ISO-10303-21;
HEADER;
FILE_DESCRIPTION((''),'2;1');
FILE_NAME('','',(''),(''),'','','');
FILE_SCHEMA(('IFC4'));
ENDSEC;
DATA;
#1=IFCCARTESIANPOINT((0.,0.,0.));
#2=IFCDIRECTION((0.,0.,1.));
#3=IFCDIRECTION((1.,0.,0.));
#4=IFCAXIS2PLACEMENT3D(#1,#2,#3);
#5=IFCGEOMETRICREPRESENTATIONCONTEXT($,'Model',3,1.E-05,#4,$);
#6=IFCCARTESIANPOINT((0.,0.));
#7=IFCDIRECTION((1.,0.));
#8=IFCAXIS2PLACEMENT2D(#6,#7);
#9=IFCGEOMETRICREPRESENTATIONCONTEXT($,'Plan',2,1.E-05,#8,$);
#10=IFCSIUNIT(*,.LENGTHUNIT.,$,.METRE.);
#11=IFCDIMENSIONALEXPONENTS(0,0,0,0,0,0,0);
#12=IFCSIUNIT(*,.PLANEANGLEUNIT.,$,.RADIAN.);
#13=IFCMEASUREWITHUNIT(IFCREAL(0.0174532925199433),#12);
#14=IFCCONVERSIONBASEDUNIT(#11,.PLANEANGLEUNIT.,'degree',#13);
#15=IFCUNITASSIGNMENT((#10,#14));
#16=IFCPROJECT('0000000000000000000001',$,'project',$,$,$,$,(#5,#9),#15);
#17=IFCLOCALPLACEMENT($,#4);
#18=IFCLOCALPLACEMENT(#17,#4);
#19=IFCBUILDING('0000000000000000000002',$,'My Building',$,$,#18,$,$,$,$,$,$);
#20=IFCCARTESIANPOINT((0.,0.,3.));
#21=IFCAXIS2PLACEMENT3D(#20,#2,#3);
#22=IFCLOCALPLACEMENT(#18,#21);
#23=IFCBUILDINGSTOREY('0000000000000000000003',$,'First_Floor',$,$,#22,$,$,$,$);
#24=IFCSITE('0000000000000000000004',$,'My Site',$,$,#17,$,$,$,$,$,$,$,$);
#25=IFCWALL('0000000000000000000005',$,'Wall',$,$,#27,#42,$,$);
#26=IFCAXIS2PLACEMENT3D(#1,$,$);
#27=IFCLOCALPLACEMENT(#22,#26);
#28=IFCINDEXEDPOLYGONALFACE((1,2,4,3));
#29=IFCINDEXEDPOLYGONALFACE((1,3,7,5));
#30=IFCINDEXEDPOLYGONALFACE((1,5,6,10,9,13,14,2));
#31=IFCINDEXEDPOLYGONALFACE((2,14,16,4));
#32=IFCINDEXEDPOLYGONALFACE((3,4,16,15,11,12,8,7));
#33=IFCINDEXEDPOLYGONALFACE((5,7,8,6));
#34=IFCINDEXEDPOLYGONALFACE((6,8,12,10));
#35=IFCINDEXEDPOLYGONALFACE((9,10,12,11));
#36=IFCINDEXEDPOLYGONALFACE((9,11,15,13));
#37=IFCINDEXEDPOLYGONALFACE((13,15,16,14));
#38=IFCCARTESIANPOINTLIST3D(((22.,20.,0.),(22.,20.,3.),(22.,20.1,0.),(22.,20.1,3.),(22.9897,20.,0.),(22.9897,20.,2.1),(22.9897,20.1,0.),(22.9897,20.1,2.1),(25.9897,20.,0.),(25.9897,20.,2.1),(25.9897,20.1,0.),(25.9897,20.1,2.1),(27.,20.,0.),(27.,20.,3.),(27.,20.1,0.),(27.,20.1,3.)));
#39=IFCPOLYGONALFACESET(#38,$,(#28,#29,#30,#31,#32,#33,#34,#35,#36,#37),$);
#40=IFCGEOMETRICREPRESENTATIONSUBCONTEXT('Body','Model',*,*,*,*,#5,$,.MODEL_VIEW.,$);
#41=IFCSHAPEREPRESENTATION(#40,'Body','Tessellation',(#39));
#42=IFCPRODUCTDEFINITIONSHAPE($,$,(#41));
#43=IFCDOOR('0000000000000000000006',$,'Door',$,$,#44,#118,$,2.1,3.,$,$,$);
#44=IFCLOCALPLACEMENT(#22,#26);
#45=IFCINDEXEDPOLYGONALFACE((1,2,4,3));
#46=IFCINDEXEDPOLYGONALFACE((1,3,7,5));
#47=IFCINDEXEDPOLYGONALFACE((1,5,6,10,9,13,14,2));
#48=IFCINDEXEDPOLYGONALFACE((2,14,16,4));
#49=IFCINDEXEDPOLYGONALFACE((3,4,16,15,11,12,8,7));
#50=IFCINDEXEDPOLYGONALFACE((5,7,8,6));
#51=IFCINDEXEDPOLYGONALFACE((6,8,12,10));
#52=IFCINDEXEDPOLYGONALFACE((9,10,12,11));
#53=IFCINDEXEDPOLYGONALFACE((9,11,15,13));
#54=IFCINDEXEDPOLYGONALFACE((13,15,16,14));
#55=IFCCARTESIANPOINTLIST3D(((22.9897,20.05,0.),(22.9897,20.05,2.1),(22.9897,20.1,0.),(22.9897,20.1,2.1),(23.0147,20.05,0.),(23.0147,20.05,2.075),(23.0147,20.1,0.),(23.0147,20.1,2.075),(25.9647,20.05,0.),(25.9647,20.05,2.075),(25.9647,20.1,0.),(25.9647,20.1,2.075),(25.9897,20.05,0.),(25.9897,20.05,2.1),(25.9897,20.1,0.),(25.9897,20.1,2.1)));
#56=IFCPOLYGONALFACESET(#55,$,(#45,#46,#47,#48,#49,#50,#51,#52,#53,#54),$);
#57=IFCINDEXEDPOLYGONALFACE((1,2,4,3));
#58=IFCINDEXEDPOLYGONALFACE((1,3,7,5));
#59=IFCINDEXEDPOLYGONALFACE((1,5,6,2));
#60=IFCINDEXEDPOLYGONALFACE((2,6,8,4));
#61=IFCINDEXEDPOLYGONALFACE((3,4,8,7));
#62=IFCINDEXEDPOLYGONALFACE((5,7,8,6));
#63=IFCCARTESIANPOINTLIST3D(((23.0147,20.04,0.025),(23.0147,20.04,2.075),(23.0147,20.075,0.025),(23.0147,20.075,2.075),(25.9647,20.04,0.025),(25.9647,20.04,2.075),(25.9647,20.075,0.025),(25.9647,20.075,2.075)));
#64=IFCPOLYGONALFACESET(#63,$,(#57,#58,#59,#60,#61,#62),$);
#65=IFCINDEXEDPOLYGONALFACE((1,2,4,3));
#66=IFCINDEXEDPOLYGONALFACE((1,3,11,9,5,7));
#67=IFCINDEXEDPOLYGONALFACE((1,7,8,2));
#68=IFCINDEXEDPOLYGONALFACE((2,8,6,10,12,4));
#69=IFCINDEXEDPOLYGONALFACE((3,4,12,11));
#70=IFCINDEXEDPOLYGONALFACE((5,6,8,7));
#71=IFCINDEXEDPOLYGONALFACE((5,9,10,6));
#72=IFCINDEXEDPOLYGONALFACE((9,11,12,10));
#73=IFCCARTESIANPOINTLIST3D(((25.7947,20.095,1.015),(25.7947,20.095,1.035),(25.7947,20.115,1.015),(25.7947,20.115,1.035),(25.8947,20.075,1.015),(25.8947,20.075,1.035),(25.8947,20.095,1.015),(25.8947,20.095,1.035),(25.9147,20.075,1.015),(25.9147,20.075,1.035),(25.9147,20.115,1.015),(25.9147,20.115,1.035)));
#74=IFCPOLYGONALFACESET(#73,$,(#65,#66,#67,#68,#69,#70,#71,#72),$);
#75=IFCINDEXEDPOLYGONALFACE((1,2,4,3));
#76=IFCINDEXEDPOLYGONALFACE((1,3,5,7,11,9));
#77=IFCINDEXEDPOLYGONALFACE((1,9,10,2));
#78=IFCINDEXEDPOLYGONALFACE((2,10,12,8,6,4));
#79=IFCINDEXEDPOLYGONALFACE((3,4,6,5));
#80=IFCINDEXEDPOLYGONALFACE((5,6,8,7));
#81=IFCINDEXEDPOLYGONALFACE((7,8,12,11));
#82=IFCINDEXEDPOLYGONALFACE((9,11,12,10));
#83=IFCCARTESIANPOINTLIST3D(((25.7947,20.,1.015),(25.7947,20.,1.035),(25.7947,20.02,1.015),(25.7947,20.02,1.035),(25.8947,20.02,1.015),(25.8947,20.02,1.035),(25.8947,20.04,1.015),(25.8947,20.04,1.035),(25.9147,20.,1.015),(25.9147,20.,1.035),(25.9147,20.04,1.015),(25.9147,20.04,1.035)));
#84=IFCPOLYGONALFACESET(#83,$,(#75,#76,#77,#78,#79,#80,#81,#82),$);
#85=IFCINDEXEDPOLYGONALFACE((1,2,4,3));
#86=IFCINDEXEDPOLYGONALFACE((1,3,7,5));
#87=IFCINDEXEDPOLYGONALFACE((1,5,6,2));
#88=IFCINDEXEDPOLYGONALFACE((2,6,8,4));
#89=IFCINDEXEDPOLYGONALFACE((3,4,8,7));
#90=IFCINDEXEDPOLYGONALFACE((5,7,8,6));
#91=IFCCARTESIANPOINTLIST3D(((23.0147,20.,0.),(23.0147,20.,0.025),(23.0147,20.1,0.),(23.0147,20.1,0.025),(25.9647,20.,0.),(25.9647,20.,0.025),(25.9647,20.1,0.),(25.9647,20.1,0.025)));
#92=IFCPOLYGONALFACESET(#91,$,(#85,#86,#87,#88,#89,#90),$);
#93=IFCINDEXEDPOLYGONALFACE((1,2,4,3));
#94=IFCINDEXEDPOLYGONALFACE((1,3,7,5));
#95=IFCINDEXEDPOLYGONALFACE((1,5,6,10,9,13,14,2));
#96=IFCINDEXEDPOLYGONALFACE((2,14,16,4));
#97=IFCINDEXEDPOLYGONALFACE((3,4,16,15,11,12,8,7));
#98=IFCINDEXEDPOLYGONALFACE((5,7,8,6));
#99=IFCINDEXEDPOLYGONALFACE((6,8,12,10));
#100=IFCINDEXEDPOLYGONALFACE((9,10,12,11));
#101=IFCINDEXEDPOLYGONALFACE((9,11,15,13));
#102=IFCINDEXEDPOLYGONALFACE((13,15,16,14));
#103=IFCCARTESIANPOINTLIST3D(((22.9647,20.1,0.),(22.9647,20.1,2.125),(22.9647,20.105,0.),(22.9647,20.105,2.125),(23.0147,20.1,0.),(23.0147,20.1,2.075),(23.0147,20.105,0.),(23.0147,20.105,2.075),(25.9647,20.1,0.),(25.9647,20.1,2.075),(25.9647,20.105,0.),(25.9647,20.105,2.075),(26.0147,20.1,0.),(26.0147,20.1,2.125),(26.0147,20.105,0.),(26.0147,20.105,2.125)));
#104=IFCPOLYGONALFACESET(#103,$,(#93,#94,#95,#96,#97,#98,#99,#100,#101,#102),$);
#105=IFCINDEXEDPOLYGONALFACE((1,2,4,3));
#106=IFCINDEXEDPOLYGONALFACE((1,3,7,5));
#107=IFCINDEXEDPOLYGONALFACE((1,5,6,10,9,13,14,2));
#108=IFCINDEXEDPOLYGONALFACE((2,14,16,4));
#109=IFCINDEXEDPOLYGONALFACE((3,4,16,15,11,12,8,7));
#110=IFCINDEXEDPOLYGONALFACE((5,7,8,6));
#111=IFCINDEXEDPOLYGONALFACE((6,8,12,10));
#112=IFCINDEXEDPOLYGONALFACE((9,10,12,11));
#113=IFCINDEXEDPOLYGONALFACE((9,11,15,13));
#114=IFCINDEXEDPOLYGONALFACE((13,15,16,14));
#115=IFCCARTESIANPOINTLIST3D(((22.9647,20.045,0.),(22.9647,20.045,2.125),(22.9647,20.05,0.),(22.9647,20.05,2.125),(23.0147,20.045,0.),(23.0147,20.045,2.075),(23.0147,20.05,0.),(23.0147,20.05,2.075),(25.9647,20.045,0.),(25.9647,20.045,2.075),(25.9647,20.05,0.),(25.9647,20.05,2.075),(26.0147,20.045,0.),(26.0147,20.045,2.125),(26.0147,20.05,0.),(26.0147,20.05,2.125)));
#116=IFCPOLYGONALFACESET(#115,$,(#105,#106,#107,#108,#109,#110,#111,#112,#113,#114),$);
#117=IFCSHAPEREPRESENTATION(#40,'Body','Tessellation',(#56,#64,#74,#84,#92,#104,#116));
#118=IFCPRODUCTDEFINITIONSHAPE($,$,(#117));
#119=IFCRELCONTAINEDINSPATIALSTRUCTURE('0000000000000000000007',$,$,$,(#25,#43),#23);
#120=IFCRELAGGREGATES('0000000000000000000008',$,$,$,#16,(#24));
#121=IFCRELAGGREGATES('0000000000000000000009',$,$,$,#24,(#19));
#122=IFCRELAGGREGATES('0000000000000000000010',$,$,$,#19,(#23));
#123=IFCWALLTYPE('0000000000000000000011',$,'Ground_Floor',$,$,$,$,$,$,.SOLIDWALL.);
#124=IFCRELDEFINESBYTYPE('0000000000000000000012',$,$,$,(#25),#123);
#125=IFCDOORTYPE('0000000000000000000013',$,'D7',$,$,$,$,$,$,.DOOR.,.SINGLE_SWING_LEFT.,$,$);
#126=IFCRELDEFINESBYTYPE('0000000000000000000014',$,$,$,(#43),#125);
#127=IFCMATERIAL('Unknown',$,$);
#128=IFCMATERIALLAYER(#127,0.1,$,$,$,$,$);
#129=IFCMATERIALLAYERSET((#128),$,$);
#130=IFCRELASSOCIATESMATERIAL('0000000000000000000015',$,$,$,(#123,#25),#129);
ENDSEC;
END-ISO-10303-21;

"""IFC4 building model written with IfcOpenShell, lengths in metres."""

from ifc_helpers import new_model, entity, si_unit, converted_unit, frame, origin_with_axes, origin_2d_with_axis, place, context, subcontext, project, spatial, line, indexed_curve, outline, extrude, shape, source, transform, mapped, material, layer, layer_set, layer_usage, type_object, type_shapes, element, fill, save


model = new_model("IFC4")

# Units and contexts
model_context = context("Model", 3, precision=1e-05, world=origin_with_axes())
plan_context = context("Plan", 2, precision=1e-05, world=origin_2d_with_axis())
body_context_1 = subcontext(model_context, "Body", "Model", "MODEL_VIEW")
body_context_2 = subcontext(plan_context, "Body", "Plan", "PLAN_VIEW")
ifc_project = project(units=[si_unit("LENGTHUNIT", "METRE"), converted_unit("PLANEANGLEUNIT", "degree", entity("IfcReal", 0.0174532925199433), si_unit("PLANEANGLEUNIT", "RADIAN"), dimensions=[0, 0, 0, 0, 0, 0, 0])], contexts=[model_context, plan_context])

# Site, building, storey
site_placement = place(None, origin_with_axes())
site = spatial("IfcSite", under=ifc_project, at=site_placement, Name="My Site")
building_placement = place(site_placement, origin_with_axes())
building = spatial("IfcBuilding", under=site, at=building_placement, Name="My Building")
storey_placement = place(building_placement, frame((0.0, 0.0, 3.0), z_axis=(0.0, 0.0, 1.0), x_axis=(1.0, 0.0, 0.0)))
storey = spatial("IfcBuildingStorey", under=building, at=storey_placement, Name="First_Floor")

# Shared definitions
ifc_material = material(Name="Unknown")

# Shared definitions
ifc_layer = layer(ifc_material, 0.1)
ifc_layer_set = layer_set([ifc_layer])
wall_type = type_object("IfcWallType", Name="Ground_Floor", PredefinedType="SOLIDWALL", material=ifc_layer_set)

# Shared definitions
shared_shape_1 = source(origin_with_axes(), body_context_1, "Body", "SweptSolid", [
    extrude(outline(indexed_curve([(0.0, 0.0), (3.0, 0.0), (3.0, 2.1), (0.0, 2.1)], segments=[line(1, 2, 3, 4, 1)])), frame((0.0, -0.6, 0.0), z_axis=(0.0, -1.0, 0.0), x_axis=(1.0, 0.0, 0.0)), (0.0, 0.0, -1.0), 1.2),
])
door_type_1 = type_object("IfcDoorType", Name="D7", OperationType="SINGLE_SWING_LEFT", PredefinedType="DOOR")
shared_shape_2 = source(origin_with_axes(), body_context_1, "Body", "SweptSolid", [
    extrude(outline(indexed_curve([(0.0, 0.0), (0.0, 2.1), (3.0, 2.1), (3.0, 0.0), (2.975, 0.0), (2.975, 2.075), (0.025, 2.075), (0.025, 0.0)], segments=[line(1, 2, 3, 4, 5, 6, 7, 8, 1)])), frame((0.0, 0.0, 0.0), z_axis=(0.0, -1.0, 0.0), x_axis=(1.0, 0.0, 0.0)), (0.0, 0.0, -1.0), 0.05),
    extrude(outline(indexed_curve([(0.0, 0.0), (2.95, 0.0), (2.95, 0.035), (0.0, 0.035)], segments=[line(1, 2, 3, 4, 1)])), frame((0.025, 0.025, 0.025), z_axis=(0.0, 0.0, 1.0), x_axis=(1.0, 0.0, 0.0)), (0.0, 0.0, 1.0), 2.05),
    extrude(outline(indexed_curve([(0.0, 0.0), (0.0, -0.04), (0.12, -0.04), (0.12, -0.02), (0.02, -0.02), (0.02, 0.0)], segments=[line(1, 2, 3, 4, 5, 6, 1)])), frame((0.075, 0.025, 1.015), z_axis=(0.0, 0.0, 1.0), x_axis=(1.0, 0.0, 0.0)), (0.0, 0.0, 1.0), 0.02),
    extrude(outline(indexed_curve([(0.0, 0.0), (0.0, 0.04), (0.12, 0.04), (0.12, 0.02), (0.02, 0.02), (0.02, 0.0)], segments=[line(1, 2, 3, 4, 5, 6, 1)])), frame((0.075, 0.06, 1.015), z_axis=(0.0, 0.0, 1.0), x_axis=(1.0, 0.0, 0.0)), (0.0, 0.0, 1.0), 0.02),
    extrude(outline(indexed_curve([(0.0, 0.0), (2.95, 0.0), (2.95, 0.1), (0.0, 0.1)], segments=[line(1, 2, 3, 4, 1)])), frame((0.025, 0.0, 0.0), z_axis=(0.0, 0.0, 1.0), x_axis=(1.0, 0.0, 0.0)), (0.0, 0.0, 1.0), 0.025),
    extrude(outline(indexed_curve([(0.0, 0.0), (0.0, 2.125), (3.05, 2.125), (3.05, 0.0), (3.0, 0.0), (3.0, 2.075), (0.05, 2.075), (0.05, 0.0)], segments=[line(1, 2, 3, 4, 5, 6, 7, 8, 1)])), frame((-0.025, -0.005, 0.0), z_axis=(0.0, -1.0, 0.0), x_axis=(1.0, 0.0, 0.0)), (0.0, 0.0, -1.0), 0.005),
    extrude(outline(indexed_curve([(0.0, 0.0), (0.0, 2.125), (3.05, 2.125), (3.05, 0.0), (3.0, 0.0), (3.0, 2.075), (0.05, 2.075), (0.05, 0.0)], segments=[line(1, 2, 3, 4, 5, 6, 7, 8, 1)])), frame((-0.025, 0.05, 0.0), z_axis=(0.0, -1.0, 0.0), x_axis=(1.0, 0.0, 0.0)), (0.0, 0.0, -1.0), 0.005),
])
shared_shape_3 = source(origin_with_axes(), body_context_2, "Body", "Curve2D", [
    entity("IfcIndexedPolyCurve", entity("IfcCartesianPointList2D", [[0.0, 0.0], [0.025, 0.0], [0.025, 0.05], [0.0, 0.05]]), [entity("IfcLineIndex", [1, 2, 3, 4, 1])]),
    entity("IfcIndexedPolyCurve", entity("IfcCartesianPointList2D", [[3.0, 0.0], [2.975, 0.0], [2.975, 0.05], [3.0, 0.05]]), [entity("IfcLineIndex", [1, 2, 3, 4, 1])]),
    entity("IfcIndexedPolyCurve", entity("IfcCartesianPointList2D", [[2.975, 0.05], [2.975, -2.9], [2.94, -2.9]])),
    entity("IfcTrimmedCurve", entity("IfcEllipse", entity("IfcAxis2Placement2D", entity("IfcCartesianPoint", [2.94, 0.05]), entity("IfcDirection", [1.0, 0.0])), 2.915, 2.95), [entity("IfcCartesianPoint", [2.94, 3.0])], [entity("IfcCartesianPoint", [2.94, -2.9])], True, "CARTESIAN"),
    entity("IfcIndexedPolyCurve", entity("IfcCartesianPointList2D", [[2.975, 0.05], [2.94, 0.05], [2.94, 3.0], [2.975, 3.0]]), [entity("IfcLineIndex", [1, 2, 3, 4, 1])]),
])
type_shapes(door_type_1, [shared_shape_2, shared_shape_3])

# Wall, opening, door
ifc_layer_usage_1 = layer_usage(ifc_layer_set, "AXIS2", "POSITIVE", 0.0)
wall_1_placement = place(storey_placement, frame((22.0, 20.0, 0.0), z_axis=(0.0, 0.0, 1.0), x_axis=(1.0, 0.0, 0.0)))
wall_1 = element("IfcWall", 1, at=wall_1_placement, inside=storey, type_object=wall_type, material=ifc_layer_usage_1, Name="Wall", context=body_context_1, shape_type="SweptSolid", body=[
    extrude(outline(indexed_curve([(0.0, 0.0), (0.0, 0.1), (5.0, 0.1), (5.0, 0.0)], segments=[line(1, 2, 3, 4, 1)])), origin_with_axes(), (0.0, 0.0, 1.0), 3.0),
])
opening_1_placement = place(wall_1_placement, frame((3.9897, 0.1, 0.0), z_axis=(0.0, 0.0, 1.0), x_axis=(-1.0, 0.0, 0.0)))
opening_1 = element("IfcOpeningElement", 2, at=opening_1_placement, cuts=wall_1, PredefinedType="OPENING", context=body_context_1, shape_type="MappedRepresentation", body=[
    mapped(shared_shape_1, transform((0.0, 0.0, 0.0), x_axis=(1.0, 0.0, 0.0), y_axis=(0.0, 1.0, 0.0), z_axis=(0.0, 0.0, 1.0), scale=1.0)),
])
door_1_placement = place(opening_1_placement, origin_with_axes())
door_1 = element("IfcDoor", 3, at=door_1_placement, inside=storey, type_object=door_type_1, Name="Door", OverallHeight=2.1, OverallWidth=3.0, shapes=[
    shape(body_context_1, "Body", "MappedRepresentation", [mapped(shared_shape_2, transform((0.0, 0.0, 0.0), x_axis=(1.0, 0.0, 0.0), y_axis=(0.0, 1.0, 0.0), z_axis=(0.0, 0.0, 1.0), scale=1.0))]),
    shape(body_context_2, "Body", "MappedRepresentation", [mapped(shared_shape_3, transform((0.0, 0.0, 0.0), x_axis=(1.0, 0.0, 0.0), y_axis=(0.0, 1.0, 0.0), z_axis=(0.0, 0.0, 1.0), scale=1.0))]),
])
fill(opening_1, door_1)

save(model, "model.ifc")
